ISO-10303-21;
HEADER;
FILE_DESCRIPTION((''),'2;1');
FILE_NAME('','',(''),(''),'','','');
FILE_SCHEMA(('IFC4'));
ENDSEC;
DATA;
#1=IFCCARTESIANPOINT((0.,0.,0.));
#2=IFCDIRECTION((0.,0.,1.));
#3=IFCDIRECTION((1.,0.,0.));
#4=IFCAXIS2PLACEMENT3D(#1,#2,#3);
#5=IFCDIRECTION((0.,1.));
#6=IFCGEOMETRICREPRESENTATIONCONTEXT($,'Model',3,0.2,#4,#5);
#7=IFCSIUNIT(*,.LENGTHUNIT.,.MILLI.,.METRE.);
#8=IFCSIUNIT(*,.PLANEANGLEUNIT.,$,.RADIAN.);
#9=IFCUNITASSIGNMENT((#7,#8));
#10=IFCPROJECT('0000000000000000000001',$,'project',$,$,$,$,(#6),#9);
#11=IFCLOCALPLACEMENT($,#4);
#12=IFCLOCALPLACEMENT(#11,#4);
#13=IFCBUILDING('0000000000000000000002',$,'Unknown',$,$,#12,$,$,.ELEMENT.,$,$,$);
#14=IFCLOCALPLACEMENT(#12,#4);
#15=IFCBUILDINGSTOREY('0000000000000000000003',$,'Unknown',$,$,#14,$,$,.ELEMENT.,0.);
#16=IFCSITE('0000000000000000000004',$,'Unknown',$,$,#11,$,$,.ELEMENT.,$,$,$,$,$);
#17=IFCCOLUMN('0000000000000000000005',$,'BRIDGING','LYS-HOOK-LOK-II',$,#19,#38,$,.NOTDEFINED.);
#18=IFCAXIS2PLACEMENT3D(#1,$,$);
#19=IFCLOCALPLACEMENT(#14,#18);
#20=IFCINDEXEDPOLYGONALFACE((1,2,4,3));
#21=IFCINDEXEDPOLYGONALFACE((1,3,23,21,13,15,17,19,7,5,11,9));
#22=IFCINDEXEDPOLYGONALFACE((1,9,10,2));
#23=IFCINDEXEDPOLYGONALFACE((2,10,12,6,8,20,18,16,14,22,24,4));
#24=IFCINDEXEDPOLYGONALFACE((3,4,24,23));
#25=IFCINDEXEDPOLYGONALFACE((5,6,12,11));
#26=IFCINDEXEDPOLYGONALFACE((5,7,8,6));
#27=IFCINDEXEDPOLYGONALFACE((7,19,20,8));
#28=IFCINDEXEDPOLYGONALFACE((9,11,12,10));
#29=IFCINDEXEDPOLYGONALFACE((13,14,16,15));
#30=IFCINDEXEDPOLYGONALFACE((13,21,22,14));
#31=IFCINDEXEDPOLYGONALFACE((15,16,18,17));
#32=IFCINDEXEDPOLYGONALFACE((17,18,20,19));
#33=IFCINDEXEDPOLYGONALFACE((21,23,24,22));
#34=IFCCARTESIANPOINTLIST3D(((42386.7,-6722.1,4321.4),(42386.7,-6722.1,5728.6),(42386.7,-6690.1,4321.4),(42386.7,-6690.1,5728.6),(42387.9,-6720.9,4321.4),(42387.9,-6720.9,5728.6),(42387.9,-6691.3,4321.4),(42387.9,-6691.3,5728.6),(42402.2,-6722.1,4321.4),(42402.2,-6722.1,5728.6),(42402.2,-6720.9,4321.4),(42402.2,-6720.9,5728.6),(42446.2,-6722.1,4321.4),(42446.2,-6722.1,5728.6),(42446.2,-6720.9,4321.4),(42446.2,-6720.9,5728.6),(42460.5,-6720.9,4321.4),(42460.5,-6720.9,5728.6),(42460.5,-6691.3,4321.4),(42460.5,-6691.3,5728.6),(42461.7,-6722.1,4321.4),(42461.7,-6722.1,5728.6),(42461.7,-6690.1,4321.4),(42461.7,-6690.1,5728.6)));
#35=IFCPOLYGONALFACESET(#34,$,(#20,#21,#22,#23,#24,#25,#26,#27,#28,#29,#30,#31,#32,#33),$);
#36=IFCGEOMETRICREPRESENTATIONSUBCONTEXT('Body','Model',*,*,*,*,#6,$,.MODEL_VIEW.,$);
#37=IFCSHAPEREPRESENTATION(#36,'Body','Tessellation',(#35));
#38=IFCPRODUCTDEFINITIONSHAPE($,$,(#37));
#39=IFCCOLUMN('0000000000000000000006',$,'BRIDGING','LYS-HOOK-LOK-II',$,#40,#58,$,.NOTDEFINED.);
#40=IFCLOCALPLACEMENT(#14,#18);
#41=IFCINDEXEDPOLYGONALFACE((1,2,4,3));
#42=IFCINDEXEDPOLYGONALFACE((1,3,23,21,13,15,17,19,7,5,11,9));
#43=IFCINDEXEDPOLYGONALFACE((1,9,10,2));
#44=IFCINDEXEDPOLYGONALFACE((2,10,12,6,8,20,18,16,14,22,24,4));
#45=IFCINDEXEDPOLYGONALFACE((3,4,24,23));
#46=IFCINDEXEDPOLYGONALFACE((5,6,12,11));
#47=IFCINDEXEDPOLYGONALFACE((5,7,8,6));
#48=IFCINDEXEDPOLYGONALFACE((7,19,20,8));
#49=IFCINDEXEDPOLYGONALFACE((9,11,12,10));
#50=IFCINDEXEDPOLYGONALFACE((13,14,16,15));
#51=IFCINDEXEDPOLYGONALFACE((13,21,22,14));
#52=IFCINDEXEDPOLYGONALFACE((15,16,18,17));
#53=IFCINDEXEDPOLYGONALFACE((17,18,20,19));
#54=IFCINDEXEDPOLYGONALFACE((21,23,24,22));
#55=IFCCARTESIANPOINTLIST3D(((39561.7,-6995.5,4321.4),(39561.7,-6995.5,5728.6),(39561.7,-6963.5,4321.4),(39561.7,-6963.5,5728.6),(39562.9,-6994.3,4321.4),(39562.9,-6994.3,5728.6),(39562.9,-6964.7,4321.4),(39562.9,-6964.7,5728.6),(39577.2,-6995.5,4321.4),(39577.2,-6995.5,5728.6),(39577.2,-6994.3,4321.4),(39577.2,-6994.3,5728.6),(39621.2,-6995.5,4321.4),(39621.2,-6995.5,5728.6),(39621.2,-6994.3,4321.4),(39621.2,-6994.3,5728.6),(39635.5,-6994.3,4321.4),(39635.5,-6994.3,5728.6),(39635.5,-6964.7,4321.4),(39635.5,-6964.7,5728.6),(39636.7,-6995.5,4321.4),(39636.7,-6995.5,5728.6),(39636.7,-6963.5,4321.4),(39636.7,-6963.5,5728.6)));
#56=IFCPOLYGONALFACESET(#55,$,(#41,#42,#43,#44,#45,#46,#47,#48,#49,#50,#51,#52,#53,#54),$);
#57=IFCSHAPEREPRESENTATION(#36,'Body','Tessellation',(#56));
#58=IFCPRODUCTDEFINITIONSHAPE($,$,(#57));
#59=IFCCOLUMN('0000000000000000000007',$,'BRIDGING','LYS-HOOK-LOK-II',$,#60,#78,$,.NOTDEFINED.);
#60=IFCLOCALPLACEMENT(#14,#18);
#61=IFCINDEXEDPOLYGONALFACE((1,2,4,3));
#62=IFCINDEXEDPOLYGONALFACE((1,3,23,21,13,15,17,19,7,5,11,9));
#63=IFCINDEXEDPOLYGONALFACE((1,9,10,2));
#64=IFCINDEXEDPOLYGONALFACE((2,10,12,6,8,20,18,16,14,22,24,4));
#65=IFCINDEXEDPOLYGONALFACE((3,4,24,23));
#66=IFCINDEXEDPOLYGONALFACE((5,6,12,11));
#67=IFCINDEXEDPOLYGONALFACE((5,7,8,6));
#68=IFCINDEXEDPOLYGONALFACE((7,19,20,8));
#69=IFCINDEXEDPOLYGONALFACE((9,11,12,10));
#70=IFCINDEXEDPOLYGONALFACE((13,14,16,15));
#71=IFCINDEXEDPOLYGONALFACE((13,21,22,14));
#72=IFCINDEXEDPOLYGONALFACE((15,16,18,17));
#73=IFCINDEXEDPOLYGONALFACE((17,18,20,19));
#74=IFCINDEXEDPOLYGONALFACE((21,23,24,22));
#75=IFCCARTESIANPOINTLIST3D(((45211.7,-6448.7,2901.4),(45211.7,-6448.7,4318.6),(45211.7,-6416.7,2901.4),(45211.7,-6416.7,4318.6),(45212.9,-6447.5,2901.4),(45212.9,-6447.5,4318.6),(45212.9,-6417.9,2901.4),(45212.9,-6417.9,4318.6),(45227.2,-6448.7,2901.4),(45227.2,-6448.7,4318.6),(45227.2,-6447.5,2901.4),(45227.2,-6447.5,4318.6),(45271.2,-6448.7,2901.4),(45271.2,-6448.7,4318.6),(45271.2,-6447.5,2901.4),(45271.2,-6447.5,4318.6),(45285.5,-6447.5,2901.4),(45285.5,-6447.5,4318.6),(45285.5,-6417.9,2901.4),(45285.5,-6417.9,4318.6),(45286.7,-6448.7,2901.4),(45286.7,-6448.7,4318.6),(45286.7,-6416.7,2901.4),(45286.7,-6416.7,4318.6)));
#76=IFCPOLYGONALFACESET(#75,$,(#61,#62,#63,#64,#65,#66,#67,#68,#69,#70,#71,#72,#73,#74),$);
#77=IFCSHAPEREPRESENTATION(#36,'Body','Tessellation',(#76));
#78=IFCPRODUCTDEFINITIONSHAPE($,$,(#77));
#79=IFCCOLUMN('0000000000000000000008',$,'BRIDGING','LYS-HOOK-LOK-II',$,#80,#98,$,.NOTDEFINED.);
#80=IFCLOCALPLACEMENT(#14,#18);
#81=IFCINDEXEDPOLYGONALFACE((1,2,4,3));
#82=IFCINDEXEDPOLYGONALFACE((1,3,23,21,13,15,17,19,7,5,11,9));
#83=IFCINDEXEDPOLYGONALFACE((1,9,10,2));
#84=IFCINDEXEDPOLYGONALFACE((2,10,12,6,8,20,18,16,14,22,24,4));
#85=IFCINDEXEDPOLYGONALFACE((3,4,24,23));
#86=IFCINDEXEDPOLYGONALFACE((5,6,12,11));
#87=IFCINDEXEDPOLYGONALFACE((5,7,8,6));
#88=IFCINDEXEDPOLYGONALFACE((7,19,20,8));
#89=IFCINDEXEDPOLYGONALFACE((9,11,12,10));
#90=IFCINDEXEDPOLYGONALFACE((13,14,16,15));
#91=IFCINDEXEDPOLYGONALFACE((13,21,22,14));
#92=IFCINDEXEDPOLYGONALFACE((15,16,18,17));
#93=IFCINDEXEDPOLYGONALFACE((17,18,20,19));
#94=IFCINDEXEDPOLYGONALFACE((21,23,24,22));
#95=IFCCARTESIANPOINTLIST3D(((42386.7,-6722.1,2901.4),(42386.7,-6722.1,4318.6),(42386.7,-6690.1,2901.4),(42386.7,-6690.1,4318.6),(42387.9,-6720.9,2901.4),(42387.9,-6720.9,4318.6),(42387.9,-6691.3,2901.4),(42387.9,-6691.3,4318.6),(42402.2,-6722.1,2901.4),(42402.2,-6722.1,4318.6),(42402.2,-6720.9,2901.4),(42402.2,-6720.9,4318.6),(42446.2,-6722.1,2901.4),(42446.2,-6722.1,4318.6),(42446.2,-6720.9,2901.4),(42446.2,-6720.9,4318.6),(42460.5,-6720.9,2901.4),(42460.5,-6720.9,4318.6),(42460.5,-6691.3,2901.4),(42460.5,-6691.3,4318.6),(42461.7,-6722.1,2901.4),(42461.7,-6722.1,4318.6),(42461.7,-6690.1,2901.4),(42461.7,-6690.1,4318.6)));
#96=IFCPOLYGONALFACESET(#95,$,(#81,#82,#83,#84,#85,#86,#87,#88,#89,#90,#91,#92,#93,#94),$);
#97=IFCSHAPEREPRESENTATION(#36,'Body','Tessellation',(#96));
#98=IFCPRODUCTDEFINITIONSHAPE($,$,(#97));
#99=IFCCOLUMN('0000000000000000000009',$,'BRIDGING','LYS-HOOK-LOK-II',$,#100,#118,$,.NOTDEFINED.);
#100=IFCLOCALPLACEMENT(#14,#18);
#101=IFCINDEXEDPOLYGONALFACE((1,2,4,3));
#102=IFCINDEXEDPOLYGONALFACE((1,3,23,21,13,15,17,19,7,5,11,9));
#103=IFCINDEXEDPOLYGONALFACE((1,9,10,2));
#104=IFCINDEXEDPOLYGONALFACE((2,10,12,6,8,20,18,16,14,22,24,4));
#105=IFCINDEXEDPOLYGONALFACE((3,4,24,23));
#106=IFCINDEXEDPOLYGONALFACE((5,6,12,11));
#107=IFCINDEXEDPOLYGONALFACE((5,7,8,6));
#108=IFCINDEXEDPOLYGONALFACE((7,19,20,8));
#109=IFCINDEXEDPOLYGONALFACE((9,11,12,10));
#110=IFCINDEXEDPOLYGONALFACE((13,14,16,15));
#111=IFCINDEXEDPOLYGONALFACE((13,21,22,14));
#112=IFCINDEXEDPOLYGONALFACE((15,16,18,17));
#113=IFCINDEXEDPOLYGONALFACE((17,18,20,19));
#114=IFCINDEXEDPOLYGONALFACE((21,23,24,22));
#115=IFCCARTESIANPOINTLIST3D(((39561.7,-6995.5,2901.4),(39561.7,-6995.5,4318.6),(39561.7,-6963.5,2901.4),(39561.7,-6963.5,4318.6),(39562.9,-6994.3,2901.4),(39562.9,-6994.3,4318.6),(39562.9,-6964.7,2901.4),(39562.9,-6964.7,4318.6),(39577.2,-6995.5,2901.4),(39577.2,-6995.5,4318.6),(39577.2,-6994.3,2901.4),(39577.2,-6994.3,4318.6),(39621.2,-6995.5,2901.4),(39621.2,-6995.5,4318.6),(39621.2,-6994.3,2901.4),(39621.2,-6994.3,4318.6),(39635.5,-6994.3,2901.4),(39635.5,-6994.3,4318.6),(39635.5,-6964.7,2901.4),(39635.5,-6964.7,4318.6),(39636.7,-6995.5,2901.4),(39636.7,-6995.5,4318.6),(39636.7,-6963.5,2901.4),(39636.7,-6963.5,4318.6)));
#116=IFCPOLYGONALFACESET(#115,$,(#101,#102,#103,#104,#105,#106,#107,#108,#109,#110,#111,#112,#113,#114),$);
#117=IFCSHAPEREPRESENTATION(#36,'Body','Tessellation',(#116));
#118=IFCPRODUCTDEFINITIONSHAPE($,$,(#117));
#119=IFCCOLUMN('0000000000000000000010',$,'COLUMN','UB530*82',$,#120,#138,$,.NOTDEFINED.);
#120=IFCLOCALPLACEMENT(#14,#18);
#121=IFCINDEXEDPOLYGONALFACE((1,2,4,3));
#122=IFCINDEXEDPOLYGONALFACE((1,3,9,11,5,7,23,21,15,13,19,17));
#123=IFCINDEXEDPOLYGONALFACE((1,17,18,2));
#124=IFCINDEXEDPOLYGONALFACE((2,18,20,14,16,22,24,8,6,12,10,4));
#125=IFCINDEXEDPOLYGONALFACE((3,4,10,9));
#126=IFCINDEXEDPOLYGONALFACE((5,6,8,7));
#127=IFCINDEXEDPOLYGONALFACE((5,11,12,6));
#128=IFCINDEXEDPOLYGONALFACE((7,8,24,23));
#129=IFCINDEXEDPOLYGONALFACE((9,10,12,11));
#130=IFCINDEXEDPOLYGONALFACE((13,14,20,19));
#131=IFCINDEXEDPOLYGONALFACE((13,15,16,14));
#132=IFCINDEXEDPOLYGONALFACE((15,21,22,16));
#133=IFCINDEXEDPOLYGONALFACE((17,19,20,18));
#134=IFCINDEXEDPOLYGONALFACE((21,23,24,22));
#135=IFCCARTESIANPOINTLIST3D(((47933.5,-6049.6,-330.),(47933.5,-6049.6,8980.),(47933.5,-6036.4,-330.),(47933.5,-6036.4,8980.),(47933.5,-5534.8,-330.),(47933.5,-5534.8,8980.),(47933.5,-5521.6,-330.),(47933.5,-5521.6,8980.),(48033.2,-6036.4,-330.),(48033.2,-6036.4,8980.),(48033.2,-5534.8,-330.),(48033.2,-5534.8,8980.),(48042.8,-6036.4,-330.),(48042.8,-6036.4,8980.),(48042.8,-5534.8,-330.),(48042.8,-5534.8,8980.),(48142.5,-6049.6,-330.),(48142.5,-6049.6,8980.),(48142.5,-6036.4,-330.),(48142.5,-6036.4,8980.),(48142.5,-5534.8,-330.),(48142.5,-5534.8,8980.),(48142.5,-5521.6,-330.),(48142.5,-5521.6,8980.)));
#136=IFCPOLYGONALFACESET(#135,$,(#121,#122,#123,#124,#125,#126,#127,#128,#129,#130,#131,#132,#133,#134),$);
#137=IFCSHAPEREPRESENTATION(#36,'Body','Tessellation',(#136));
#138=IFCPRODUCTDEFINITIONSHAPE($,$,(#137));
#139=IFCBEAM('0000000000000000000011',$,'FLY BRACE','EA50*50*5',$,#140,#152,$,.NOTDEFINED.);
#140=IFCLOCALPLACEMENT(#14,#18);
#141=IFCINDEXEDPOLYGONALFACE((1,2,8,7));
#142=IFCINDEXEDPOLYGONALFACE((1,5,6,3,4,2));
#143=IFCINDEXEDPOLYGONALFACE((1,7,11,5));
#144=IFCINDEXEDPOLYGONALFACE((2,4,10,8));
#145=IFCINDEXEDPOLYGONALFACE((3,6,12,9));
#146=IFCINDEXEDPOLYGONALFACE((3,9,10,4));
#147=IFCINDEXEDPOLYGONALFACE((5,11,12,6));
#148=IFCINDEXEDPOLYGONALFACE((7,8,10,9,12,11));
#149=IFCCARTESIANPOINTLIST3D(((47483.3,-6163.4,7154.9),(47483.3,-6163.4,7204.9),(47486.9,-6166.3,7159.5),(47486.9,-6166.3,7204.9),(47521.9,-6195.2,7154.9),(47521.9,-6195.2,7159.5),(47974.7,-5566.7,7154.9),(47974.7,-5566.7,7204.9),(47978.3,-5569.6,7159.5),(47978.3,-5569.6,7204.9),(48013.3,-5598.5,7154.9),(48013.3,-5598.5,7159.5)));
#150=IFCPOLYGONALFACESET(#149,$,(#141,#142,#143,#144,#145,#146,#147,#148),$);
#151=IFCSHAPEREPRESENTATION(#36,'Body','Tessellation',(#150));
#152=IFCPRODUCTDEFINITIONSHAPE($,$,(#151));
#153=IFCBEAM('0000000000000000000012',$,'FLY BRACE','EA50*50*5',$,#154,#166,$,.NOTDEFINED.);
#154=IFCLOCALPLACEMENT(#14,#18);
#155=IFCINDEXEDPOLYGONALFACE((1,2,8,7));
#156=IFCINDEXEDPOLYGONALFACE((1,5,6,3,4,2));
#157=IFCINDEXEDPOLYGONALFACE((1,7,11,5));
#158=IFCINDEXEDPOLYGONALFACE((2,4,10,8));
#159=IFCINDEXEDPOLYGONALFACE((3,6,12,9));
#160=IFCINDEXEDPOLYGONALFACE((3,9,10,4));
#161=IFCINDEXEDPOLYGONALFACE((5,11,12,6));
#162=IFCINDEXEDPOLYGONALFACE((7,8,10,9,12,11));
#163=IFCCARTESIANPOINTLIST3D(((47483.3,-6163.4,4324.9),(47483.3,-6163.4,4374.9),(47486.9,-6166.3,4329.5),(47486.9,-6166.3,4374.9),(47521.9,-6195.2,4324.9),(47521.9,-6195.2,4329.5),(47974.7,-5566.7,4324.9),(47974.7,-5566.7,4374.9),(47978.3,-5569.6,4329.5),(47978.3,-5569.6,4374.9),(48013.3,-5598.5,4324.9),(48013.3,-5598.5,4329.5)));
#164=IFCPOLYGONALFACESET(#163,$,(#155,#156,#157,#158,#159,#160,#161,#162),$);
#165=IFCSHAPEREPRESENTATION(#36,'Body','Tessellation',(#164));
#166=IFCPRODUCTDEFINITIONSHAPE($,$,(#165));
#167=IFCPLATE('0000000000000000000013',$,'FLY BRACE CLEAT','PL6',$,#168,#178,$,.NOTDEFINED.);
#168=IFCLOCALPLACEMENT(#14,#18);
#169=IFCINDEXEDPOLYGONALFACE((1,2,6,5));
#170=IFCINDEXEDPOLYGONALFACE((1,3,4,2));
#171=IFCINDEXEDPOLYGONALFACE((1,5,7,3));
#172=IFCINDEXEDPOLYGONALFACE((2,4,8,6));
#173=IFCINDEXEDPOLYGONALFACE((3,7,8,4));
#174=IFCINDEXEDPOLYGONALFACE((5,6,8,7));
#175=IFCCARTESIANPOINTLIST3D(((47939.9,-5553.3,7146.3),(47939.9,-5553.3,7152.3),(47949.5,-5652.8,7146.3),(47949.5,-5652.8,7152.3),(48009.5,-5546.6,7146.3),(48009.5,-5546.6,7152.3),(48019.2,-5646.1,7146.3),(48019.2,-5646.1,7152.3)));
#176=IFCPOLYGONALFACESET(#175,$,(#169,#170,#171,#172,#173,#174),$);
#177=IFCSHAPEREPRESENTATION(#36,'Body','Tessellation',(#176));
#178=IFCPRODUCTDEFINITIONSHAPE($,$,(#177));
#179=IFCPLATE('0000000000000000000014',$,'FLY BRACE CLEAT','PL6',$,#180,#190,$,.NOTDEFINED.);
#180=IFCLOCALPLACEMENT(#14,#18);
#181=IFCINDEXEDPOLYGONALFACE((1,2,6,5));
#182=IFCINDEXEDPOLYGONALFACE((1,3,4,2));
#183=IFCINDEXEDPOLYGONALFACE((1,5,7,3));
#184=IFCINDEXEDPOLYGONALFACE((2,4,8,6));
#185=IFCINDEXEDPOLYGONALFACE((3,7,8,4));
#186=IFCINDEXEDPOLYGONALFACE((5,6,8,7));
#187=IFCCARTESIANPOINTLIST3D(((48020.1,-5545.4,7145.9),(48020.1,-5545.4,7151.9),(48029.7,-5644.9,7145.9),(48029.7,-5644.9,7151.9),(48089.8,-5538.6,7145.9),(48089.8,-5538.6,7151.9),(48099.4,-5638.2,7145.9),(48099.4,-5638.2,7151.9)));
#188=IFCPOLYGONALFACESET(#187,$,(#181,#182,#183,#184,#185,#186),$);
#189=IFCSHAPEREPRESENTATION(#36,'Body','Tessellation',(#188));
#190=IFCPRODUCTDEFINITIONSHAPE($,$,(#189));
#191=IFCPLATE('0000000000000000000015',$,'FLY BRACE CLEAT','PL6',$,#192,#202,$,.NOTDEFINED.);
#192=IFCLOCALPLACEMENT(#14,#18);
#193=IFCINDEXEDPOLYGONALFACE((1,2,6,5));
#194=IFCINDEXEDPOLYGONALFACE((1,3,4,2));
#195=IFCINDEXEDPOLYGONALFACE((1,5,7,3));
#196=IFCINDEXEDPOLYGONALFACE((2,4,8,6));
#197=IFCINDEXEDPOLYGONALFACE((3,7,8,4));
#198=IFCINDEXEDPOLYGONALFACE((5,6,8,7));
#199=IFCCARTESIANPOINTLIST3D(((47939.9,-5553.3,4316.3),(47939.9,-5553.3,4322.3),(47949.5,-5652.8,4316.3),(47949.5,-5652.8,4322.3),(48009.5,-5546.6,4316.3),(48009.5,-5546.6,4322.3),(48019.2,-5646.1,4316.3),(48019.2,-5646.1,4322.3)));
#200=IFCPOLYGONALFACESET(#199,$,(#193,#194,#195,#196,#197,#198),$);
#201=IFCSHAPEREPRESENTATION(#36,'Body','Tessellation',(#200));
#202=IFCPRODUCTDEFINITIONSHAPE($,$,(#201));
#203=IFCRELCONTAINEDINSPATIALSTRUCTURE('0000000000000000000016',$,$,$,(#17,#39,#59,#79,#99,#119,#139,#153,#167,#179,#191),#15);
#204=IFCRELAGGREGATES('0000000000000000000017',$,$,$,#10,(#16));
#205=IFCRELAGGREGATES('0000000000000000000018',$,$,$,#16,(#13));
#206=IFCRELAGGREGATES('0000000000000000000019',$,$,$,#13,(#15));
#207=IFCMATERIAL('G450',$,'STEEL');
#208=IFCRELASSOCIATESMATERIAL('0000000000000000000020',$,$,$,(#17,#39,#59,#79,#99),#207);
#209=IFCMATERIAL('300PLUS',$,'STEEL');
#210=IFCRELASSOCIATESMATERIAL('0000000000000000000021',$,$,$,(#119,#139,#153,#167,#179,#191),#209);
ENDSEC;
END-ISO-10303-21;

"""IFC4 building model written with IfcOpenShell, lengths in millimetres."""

from ifc_helpers import new_model, si_unit, direction, frame, origin_with_axes, place, context, subcontext, project, spatial, line, indexed_curve, outline, extrude, material, element, save


model = new_model("IFC4")

# Units and contexts
model_context = context("Model", 3, precision=0.2, world=origin_with_axes(), true_north=direction((0.0, 1.0)))
body_context = subcontext(model_context, "Body", "Model", "MODEL_VIEW")
ifc_project = project(units=[si_unit("LENGTHUNIT", "METRE", prefix="MILLI"), si_unit("PLANEANGLEUNIT", "RADIAN")], contexts=[model_context])

# Site, building, storey
site_placement = place(None, origin_with_axes())
site = spatial("IfcSite", under=ifc_project, at=site_placement, Name="Unknown", CompositionType="ELEMENT")
building_placement = place(site_placement, origin_with_axes())
building = spatial("IfcBuilding", under=site, at=building_placement, Name="Unknown", CompositionType="ELEMENT")
storey_placement = place(building_placement, origin_with_axes())
storey = spatial("IfcBuildingStorey", under=building, at=storey_placement, Name="Unknown", CompositionType="ELEMENT", Elevation=0.0)

# Columns
ifc_material_1 = material(Name="G450", Category="STEEL")
for number, where, z_axis, x_axis, name in (
    (1, (42424.2, -6706.1, 4321.4), (0.0, -1.0, 0.0), (0.0, 0.0, 1.0), "BRIDGING"),
    (2, (39599.2, -6979.5, 4321.4), (0.0, -1.0, 0.0), (0.0, 0.0, 1.0), "BRIDGING"),
):
    element("IfcColumn", number, at=place(storey_placement, frame(where, z_axis=z_axis, x_axis=x_axis)), inside=storey, material=ifc_material_1, Name=name, Description="LYS-HOOK-LOK-II", PredefinedType="NOTDEFINED", context=body_context, shape_type="SolidModel", body=[
        extrude(outline(indexed_curve([(16.0, -37.5), (16.0, -22.0), (14.8, -22.0), (14.8, -36.3), (-14.8, -36.3), (-14.8, 36.3), (14.8, 36.3), (14.8, 22.0), (16.0, 22.0), (16.0, 37.5), (-16.0, 37.5), (-16.0, -37.5)], segments=[line(1, 2, 3, 4, 5, 6, 7, 8, 9, 10, 11, 12, 1)])), frame((0.0, 0.0, 0.0), z_axis=(-1.0, 0.0, 0.0), x_axis=(0.0, 0.0, 1.0)), (0.0, 0.0, -1.0), 1407.2),
    ])
for number, where, z_axis, x_axis, name in (
    (3, (45249.2, -6432.7, 2901.4), (0.0, -1.0, 0.0), (0.0, 0.0, 1.0), "BRIDGING"),
    (4, (42424.2, -6706.1, 2901.4), (0.0, -1.0, 0.0), (0.0, 0.0, 1.0), "BRIDGING"),
    (5, (39599.2, -6979.5, 2901.4), (0.0, -1.0, 0.0), (0.0, 0.0, 1.0), "BRIDGING"),
):
    element("IfcColumn", number, at=place(storey_placement, frame(where, z_axis=z_axis, x_axis=x_axis)), inside=storey, material=ifc_material_1, Name=name, Description="LYS-HOOK-LOK-II", PredefinedType="NOTDEFINED", context=body_context, shape_type="SolidModel", body=[
        extrude(outline(indexed_curve([(16.0, -37.5), (16.0, -22.0), (14.8, -22.0), (14.8, -36.3), (-14.8, -36.3), (-14.8, 36.3), (14.8, 36.3), (14.8, 22.0), (16.0, 22.0), (16.0, 37.5), (-16.0, 37.5), (-16.0, -37.5)], segments=[line(1, 2, 3, 4, 5, 6, 7, 8, 9, 10, 11, 12, 1)])), frame((0.0, 0.0, 0.0), z_axis=(-1.0, 0.0, 0.0), x_axis=(0.0, 0.0, 1.0)), (0.0, 0.0, -1.0), 1417.2),
    ])
ifc_material_2 = material(Name="300PLUS", Category="STEEL")
column_placement = place(storey_placement, frame((48038.0, -5785.6, -330.0), z_axis=(-1.0, 0.0, 0.0), x_axis=(0.0, 0.0, 1.0)))
element("IfcColumn", 6, at=column_placement, inside=storey, material=ifc_material_2, Name="COLUMN", Description="UB530*82", PredefinedType="NOTDEFINED", context=body_context, shape_type="SolidModel", body=[
    extrude(outline(indexed_curve([(-104.5, -264.0), (104.5, -264.0), (104.5, -250.8), (4.8, -250.8), (4.8, 250.8), (104.5, 250.8), (104.5, 264.0), (-104.5, 264.0), (-104.5, 250.8), (-4.8, 250.8), (-4.8, -250.8), (-104.5, -250.8)], segments=[line(1, 2, 3, 4, 5, 6, 7, 8, 9, 10, 11, 12, 1)])), frame((0.0, 0.0, 0.0), z_axis=(-1.0, 0.0, 0.0), x_axis=(0.0, 0.0, 1.0)), (0.0, 0.0, -1.0), 9310.0),
])

# Beams
for number, where, z_axis, x_axis, name in (
    (7, (47994.0, -5582.6, 7179.9), (0.0, 0.0, 1.0), (-0.635707, -0.77193, 0.0), "FLY BRACE"),
    (8, (47994.0, -5582.6, 4349.9), (0.0, 0.0, 1.0), (-0.635707, -0.77193, 0.0), "FLY BRACE"),
):
    element("IfcBeam", number, at=place(storey_placement, frame(where, z_axis=z_axis, x_axis=x_axis)), inside=storey, material=ifc_material_2, Name=name, Description="EA50*50*5", PredefinedType="NOTDEFINED", context=body_context, shape_type="SolidModel", body=[
        extrude(outline(indexed_curve([(-25.0, -25.0), (25.0, -25.0), (25.0, -20.4), (-20.4, -20.4), (-20.4, 25.0), (-25.0, 25.0)], segments=[line(1, 2, 3, 4, 5, 6, 1)])), frame((0.0, 0.0, 0.0), z_axis=(-1.0, 0.0, 0.0), x_axis=(0.0, 0.0, 1.0)), (0.0, 0.0, -1.0), 773.0),
    ])

# Plates
plate_1_placement = place(storey_placement, frame((48009.5, -5546.6, 7149.3), z_axis=(0.0, 0.0, 1.0), x_axis=(-0.995399, -0.095821, 0.0)))
element("IfcPlate", 9, at=plate_1_placement, inside=storey, material=ifc_material_2, Name="FLY BRACE CLEAT", Description="PL6", PredefinedType="NOTDEFINED", context=body_context, shape_type="SolidModel", body=[
    extrude(outline(indexed_curve([(0.0, 0.0), (69.9, 0.0), (69.9, 100.0), (-0.1, 100.0)], segments=[line(1, 2, 3, 4, 1)])), frame((0.0, 0.0, 3.0), z_axis=(0.0, 0.0, 1.0), x_axis=(1.0, 0.0, 0.0)), (0.0, 0.0, -1.0), 6.0),
])
plate_2_placement = place(storey_placement, frame((48029.7, -5644.9, 7148.9), z_axis=(0.0, 0.0, 1.0), x_axis=(0.995412, 0.095685, 0.0)))
element("IfcPlate", 10, at=plate_2_placement, inside=storey, material=ifc_material_2, Name="FLY BRACE CLEAT", Description="PL6", PredefinedType="NOTDEFINED", context=body_context, shape_type="SolidModel", body=[
    extrude(outline(indexed_curve([(0.0, 0.0), (70.0, 0.0), (70.0, 100.1), (0.0, 100.0)], segments=[line(1, 2, 3, 4, 1)])), frame((0.0, 0.0, 3.0), z_axis=(0.0, 0.0, 1.0), x_axis=(1.0, 0.0, 0.0)), (0.0, 0.0, -1.0), 6.0),
])
plate_3_placement = place(storey_placement, frame((48009.5, -5546.6, 4319.3), z_axis=(0.0, 0.0, 1.0), x_axis=(-0.995399, -0.095821, 0.0)))
element("IfcPlate", 11, at=plate_3_placement, inside=storey, material=ifc_material_2, Name="FLY BRACE CLEAT", Description="PL6", PredefinedType="NOTDEFINED", context=body_context, shape_type="SolidModel", body=[
    extrude(outline(indexed_curve([(0.0, 0.0), (69.9, 0.0), (69.9, 100.0), (-0.1, 100.0)], segments=[line(1, 2, 3, 4, 1)])), frame((0.0, 0.0, 3.0), z_axis=(0.0, 0.0, 1.0), x_axis=(1.0, 0.0, 0.0)), (0.0, 0.0, -1.0), 6.0),
])

save(model, "model.ifc")
